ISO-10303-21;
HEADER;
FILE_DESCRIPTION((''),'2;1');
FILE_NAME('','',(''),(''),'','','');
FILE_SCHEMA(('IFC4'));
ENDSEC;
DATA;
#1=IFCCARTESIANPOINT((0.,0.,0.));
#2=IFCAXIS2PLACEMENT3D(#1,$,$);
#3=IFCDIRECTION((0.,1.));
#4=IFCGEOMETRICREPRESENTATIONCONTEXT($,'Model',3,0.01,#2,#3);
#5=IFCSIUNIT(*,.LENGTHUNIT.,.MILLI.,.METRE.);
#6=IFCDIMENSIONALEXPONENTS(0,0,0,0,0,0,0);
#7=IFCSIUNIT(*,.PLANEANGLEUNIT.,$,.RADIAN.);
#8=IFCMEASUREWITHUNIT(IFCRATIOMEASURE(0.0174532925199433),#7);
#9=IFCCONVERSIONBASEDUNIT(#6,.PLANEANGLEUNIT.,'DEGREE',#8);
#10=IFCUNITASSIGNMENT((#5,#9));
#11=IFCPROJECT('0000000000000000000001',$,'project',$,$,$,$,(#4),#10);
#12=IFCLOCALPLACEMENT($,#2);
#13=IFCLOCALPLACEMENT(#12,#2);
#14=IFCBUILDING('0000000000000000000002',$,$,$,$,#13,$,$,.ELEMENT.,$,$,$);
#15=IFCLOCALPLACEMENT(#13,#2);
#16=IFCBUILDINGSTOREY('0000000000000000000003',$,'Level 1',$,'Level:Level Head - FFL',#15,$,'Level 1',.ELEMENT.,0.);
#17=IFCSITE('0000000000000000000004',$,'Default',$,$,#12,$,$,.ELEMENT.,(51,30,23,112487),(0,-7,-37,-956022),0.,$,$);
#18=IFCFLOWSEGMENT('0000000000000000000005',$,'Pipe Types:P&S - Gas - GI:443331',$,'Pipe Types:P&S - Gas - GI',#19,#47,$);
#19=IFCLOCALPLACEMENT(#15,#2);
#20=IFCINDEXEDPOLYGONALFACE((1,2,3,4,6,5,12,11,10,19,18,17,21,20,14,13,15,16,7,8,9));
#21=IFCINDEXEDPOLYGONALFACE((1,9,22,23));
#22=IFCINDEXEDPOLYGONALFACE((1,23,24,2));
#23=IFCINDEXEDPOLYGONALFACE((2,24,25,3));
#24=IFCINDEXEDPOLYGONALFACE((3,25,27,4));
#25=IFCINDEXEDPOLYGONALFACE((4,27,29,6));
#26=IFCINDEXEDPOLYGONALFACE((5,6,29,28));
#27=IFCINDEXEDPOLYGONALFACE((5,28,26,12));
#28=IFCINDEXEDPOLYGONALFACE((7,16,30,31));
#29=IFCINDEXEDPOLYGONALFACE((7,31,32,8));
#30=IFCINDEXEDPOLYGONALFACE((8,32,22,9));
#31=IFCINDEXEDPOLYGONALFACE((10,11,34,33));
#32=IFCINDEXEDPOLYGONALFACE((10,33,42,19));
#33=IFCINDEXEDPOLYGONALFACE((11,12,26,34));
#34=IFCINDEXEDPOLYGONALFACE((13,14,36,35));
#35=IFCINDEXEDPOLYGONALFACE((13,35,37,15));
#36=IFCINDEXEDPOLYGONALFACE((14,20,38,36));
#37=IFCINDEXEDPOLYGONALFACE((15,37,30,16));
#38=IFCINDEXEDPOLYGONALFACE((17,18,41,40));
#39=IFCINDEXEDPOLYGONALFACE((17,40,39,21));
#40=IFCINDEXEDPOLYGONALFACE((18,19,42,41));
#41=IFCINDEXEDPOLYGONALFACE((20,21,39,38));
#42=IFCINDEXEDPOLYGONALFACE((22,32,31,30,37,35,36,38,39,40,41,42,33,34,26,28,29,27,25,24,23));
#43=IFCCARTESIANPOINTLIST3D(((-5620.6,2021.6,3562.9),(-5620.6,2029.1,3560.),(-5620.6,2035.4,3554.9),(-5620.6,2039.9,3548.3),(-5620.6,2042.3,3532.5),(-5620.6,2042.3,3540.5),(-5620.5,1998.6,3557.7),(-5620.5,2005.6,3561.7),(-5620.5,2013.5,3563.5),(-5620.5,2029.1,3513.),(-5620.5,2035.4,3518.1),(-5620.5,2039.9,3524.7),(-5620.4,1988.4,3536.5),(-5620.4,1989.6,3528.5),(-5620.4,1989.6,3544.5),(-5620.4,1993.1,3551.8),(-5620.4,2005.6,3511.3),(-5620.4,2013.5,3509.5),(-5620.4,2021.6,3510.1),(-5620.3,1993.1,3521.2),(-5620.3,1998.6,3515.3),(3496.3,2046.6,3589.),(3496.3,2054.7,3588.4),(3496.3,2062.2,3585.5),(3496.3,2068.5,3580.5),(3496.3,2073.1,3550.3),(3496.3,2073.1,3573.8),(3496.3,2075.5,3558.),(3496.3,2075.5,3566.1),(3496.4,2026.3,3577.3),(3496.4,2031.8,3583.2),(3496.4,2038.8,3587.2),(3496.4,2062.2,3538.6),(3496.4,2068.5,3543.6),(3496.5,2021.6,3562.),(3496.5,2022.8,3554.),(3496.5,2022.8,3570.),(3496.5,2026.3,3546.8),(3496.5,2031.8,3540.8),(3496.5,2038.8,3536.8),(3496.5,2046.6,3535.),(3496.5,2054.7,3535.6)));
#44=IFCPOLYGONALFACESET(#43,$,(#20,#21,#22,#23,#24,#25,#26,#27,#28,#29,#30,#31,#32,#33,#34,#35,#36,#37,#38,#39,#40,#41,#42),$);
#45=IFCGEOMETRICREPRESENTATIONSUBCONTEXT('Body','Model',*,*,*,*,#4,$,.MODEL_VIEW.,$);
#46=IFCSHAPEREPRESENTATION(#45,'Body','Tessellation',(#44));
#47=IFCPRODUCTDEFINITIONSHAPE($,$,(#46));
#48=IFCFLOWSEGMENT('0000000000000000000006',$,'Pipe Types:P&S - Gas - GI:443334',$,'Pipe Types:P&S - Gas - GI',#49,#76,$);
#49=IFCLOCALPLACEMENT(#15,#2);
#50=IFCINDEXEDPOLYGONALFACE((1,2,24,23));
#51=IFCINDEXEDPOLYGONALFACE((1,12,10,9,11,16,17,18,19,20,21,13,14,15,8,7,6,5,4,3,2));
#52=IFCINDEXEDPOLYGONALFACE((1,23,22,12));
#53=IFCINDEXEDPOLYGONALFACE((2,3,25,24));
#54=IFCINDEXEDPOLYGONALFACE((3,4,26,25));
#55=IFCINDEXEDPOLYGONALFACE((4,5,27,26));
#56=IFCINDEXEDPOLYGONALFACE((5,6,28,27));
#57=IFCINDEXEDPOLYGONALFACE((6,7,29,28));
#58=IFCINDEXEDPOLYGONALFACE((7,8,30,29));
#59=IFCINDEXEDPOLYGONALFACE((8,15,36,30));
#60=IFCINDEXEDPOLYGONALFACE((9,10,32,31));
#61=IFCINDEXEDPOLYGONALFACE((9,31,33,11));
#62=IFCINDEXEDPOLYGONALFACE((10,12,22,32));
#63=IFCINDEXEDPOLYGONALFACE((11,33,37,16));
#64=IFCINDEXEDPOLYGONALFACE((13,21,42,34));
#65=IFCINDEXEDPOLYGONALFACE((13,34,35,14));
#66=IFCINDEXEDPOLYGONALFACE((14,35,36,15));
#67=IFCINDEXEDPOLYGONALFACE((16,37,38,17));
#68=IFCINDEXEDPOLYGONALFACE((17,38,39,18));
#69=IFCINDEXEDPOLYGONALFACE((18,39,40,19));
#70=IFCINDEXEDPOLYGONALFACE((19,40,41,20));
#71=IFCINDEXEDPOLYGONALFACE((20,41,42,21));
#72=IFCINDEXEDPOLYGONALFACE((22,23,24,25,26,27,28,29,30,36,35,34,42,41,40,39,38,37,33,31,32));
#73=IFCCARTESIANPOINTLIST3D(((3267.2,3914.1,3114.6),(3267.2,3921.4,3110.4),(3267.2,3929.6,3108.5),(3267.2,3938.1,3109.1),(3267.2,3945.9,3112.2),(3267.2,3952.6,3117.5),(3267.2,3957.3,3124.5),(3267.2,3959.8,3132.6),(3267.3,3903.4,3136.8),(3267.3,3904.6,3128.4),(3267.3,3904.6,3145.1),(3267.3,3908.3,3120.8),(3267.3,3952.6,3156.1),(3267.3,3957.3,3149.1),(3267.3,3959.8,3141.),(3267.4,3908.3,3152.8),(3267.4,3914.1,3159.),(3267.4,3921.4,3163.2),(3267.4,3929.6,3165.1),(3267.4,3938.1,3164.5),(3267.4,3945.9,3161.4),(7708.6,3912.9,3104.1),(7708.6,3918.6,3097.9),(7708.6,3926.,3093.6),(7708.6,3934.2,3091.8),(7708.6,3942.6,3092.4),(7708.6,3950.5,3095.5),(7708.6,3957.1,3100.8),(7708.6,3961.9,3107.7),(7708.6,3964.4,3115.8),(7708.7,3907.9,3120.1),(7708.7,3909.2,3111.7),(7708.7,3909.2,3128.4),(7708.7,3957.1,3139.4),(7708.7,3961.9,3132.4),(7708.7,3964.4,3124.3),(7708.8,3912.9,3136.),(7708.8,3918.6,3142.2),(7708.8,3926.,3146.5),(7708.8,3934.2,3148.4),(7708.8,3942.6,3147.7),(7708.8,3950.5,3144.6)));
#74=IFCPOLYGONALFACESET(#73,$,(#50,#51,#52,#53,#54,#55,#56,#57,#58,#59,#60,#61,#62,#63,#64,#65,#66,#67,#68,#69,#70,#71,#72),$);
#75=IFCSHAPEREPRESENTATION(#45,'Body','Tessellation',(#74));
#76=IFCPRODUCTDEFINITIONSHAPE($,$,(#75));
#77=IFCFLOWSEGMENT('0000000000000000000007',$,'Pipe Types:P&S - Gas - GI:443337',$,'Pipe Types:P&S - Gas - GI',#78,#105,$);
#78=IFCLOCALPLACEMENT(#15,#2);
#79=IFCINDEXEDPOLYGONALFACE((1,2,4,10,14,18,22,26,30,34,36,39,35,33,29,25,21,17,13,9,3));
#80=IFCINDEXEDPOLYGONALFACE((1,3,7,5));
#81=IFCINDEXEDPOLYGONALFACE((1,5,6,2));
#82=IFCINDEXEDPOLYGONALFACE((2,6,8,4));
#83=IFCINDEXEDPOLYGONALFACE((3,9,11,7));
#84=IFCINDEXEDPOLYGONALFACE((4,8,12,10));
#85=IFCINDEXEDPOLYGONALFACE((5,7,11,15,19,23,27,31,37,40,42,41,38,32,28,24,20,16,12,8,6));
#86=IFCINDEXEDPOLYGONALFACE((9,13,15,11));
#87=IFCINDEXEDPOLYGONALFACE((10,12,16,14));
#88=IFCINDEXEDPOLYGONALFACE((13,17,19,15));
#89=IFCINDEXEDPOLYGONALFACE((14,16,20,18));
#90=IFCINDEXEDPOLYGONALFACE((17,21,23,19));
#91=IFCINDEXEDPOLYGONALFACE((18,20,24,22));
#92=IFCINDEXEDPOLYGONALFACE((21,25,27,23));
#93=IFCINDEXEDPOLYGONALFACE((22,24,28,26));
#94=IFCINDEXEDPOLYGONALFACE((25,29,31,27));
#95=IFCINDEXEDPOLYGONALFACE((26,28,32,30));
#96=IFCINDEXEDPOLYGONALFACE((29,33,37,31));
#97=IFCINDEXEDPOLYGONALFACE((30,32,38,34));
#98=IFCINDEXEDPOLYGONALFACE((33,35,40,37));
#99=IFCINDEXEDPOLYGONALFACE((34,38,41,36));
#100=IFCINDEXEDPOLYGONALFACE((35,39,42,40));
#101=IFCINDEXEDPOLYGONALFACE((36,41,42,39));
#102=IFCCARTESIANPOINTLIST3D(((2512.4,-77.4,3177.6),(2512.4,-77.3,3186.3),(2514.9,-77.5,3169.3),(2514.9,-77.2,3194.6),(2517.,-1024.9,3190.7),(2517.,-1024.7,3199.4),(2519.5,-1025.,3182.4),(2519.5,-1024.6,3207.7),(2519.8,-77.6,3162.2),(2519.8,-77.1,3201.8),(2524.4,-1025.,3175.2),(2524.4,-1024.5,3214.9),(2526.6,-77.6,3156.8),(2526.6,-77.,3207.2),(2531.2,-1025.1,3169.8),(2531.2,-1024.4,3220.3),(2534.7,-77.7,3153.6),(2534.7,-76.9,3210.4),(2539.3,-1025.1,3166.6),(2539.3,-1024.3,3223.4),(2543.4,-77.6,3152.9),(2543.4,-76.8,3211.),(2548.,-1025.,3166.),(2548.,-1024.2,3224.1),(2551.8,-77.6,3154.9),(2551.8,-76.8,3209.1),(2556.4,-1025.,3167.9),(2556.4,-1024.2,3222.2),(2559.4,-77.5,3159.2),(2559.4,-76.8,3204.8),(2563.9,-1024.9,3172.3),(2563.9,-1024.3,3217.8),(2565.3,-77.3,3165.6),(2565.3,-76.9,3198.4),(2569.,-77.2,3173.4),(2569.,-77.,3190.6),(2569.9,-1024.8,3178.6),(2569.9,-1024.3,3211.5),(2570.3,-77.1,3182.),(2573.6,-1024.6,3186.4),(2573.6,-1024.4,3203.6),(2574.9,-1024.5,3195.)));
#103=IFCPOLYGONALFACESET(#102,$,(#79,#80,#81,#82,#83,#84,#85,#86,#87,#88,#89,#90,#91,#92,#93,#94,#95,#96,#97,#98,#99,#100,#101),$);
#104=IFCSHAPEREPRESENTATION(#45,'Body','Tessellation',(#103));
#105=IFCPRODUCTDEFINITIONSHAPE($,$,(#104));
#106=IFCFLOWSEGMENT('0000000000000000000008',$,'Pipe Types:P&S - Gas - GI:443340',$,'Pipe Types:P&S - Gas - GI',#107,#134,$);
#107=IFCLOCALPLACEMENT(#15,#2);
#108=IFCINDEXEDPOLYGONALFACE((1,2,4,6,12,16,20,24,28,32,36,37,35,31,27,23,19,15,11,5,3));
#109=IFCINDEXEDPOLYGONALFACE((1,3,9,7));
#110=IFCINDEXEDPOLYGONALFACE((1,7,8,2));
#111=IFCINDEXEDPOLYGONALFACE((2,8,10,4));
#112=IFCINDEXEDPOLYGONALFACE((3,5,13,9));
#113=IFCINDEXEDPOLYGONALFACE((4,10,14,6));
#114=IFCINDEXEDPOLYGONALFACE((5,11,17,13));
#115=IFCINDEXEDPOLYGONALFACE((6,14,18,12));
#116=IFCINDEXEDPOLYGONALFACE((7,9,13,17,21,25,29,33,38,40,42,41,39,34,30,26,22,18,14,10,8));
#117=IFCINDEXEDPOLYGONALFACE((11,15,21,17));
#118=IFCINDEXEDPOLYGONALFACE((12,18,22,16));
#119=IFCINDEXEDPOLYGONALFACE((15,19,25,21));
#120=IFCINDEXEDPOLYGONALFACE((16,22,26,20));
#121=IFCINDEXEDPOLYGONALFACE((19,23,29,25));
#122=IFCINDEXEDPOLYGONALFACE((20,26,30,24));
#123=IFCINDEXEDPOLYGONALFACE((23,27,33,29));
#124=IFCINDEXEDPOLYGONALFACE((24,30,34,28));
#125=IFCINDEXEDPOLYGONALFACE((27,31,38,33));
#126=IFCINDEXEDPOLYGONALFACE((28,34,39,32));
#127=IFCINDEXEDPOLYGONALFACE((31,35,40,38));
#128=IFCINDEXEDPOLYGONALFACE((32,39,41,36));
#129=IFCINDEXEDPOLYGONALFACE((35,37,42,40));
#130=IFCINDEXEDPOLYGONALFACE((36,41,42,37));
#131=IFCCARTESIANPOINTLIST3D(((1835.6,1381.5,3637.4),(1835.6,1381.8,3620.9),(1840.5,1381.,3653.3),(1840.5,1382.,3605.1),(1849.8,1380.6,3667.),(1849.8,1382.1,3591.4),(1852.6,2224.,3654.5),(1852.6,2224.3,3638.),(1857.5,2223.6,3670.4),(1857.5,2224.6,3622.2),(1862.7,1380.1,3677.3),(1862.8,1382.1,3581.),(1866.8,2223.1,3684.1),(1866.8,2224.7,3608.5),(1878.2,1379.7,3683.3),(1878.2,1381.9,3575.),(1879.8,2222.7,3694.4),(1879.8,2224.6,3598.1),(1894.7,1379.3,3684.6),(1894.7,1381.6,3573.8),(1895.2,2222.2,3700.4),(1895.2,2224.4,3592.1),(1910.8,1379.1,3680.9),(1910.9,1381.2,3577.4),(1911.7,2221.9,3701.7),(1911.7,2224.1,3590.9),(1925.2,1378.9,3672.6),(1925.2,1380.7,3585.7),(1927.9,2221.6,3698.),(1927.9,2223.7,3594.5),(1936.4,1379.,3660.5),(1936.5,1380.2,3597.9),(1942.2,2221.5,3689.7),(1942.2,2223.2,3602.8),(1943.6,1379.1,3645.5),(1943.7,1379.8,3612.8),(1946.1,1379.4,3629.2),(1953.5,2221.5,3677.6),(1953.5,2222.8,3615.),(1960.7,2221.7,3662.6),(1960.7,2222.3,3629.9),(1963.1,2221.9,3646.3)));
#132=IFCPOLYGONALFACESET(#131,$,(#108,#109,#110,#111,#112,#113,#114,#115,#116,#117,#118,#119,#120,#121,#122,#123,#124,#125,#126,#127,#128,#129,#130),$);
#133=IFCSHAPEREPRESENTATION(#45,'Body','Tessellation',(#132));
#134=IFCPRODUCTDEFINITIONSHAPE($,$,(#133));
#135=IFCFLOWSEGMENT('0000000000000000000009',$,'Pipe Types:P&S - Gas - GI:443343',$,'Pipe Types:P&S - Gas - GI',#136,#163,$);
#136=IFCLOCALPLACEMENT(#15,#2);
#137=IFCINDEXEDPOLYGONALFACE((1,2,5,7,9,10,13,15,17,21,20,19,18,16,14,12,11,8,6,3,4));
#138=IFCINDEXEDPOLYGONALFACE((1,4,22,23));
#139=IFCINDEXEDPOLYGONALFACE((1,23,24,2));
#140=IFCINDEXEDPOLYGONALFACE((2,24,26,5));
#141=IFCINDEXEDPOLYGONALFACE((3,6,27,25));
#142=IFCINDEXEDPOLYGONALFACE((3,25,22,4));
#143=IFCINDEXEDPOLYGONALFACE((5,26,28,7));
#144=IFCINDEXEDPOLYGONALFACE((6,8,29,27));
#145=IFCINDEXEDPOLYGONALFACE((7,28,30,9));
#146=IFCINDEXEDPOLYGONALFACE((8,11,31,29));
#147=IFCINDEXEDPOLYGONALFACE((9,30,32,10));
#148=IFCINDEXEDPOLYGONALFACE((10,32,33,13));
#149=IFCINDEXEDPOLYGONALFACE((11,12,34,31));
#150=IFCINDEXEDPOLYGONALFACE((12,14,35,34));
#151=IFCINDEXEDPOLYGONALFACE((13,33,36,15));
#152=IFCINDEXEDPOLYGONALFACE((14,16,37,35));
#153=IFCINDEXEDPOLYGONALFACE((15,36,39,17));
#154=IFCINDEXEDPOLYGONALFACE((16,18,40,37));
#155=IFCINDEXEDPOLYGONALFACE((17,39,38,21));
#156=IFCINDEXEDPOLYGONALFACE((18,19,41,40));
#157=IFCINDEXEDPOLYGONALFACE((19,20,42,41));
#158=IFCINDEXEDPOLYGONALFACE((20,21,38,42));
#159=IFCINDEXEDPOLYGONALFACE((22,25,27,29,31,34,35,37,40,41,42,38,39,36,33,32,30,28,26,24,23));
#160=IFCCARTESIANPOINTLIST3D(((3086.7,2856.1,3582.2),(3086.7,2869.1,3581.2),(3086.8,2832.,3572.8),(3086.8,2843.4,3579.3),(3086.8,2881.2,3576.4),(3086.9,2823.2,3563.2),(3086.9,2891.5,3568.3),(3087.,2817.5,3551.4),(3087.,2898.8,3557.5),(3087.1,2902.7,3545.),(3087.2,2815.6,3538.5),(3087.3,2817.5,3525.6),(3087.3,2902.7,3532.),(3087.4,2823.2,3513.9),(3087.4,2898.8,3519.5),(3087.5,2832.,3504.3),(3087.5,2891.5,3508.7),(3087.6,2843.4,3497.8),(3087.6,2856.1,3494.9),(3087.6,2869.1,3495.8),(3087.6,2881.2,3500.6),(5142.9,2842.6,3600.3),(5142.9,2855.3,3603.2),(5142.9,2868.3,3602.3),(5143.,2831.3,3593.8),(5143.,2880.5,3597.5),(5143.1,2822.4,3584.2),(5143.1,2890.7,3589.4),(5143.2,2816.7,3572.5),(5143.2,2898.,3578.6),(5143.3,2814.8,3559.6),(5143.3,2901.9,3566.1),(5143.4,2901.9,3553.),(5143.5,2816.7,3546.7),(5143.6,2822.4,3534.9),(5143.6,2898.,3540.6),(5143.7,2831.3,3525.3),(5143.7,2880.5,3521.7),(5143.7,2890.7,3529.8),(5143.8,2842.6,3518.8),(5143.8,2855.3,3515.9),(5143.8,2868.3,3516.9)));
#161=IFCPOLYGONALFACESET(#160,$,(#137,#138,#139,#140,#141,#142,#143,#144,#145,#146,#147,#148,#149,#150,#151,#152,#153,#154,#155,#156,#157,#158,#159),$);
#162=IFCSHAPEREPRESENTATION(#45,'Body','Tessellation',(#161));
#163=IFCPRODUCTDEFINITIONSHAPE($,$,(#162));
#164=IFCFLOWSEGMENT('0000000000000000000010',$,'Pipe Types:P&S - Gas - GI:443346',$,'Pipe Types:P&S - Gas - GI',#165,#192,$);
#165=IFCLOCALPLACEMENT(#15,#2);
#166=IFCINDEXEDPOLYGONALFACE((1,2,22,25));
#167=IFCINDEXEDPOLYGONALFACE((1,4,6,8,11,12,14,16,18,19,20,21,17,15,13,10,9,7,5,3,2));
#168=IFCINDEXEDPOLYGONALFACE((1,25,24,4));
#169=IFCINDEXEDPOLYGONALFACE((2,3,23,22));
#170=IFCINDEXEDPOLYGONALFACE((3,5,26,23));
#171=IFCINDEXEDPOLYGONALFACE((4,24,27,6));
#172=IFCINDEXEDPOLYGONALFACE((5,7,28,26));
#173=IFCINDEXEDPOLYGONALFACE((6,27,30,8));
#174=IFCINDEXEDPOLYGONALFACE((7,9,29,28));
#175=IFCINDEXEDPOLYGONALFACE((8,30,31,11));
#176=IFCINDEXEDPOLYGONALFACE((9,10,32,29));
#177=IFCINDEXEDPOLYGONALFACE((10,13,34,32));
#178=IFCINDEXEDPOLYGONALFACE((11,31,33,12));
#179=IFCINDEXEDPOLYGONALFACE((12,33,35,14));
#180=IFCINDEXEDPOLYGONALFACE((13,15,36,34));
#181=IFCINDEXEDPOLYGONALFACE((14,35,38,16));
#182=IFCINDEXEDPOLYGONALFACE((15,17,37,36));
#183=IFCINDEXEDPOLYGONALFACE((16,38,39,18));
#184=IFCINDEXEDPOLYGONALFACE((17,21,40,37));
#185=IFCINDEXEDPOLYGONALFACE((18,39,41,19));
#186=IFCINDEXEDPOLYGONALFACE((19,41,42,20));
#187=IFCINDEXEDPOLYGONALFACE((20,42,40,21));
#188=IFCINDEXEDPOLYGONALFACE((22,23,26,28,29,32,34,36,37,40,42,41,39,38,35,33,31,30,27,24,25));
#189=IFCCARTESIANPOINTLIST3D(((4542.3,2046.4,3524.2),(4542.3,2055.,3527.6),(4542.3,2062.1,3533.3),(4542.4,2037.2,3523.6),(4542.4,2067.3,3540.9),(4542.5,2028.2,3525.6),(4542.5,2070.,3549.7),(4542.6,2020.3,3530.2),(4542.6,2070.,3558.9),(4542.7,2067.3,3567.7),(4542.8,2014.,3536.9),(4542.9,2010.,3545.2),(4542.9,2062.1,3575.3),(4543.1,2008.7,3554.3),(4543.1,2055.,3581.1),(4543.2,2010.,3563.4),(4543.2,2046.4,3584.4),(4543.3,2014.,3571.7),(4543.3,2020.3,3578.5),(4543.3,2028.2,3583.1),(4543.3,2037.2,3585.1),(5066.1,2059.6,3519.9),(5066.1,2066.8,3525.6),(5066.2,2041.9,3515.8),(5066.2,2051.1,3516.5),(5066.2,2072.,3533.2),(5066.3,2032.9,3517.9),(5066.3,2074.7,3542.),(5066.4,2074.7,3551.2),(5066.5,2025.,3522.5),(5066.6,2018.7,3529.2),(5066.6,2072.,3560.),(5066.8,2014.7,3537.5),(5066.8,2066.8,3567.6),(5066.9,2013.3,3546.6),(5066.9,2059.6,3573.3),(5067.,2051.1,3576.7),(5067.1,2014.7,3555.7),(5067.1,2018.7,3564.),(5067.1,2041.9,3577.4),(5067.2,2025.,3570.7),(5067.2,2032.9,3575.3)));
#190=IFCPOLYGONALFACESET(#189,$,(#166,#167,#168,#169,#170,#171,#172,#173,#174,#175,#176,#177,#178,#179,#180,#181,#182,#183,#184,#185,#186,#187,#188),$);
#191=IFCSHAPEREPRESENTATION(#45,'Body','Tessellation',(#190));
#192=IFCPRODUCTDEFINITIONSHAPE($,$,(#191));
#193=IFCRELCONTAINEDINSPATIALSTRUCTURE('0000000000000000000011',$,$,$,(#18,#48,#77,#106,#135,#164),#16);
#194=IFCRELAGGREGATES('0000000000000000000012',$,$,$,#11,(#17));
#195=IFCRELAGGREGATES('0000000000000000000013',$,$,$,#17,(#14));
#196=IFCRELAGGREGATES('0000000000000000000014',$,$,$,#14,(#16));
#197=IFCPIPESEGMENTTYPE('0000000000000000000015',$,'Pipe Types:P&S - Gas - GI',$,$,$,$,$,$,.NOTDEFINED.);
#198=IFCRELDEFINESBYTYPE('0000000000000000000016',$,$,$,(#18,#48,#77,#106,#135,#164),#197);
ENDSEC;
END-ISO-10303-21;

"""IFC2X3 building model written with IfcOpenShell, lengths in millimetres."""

from ifc_helpers import new_model, entity, si_unit, converted_unit, direction, frame, frame_2d, origin, origin_2d_with_axis, place, context, subcontext, project, spatial, circle, extrude, type_object, element, save


model = new_model("IFC2X3")

# Units and contexts
model_context = context("Model", 3, precision=0.01, world=origin(), true_north=direction((0.0, 1.0)))
body_context = subcontext(model_context, "Body", "Model", "MODEL_VIEW")
ifc_project = project(units=[si_unit("LENGTHUNIT", "METRE", prefix="MILLI"), converted_unit("PLANEANGLEUNIT", "DEGREE", entity("IfcRatioMeasure", 0.0174532925199433), si_unit("PLANEANGLEUNIT", "RADIAN"), dimensions=[0, 0, 0, 0, 0, 0, 0])], contexts=[model_context])

# Site, building, storey
site_placement = place(None, origin())
site = spatial("IfcSite", under=ifc_project, at=site_placement, Name="Default", CompositionType="ELEMENT", RefLatitude=(51, 30, 23, 112487), RefLongitude=(0, -7, -37, -956022), RefElevation=0.0)
building_placement = place(site_placement, origin())
building = spatial("IfcBuilding", under=site, at=building_placement, CompositionType="ELEMENT")
storey_placement = place(building_placement, origin())
storey = spatial("IfcBuildingStorey", under=building, at=storey_placement, Name="Level 1", ObjectType="Level:Level Head - FFL", LongName="Level 1", CompositionType="ELEMENT", Elevation=0.0)

# Flow segments
pipe_segment_type = type_object("IfcPipeSegmentType", Name="Pipe Types:P&S - Gas - GI", PredefinedType="NOTDEFINED")
flow_segment_1_placement = place(storey_placement, origin())
element("IfcFlowSegment", 1, at=flow_segment_1_placement, inside=storey, type_object=pipe_segment_type, Name="Pipe Types:P&S - Gas - GI:443331", ObjectType="Pipe Types:P&S - Gas - GI", context=body_context, shape_type="SweptSolid", body=[
    extrude(circle(Radius=27.1, at=origin_2d_with_axis()), frame((-5620.5, 2015.5, 3536.5), z_axis=(0.999989, 0.003634, 0.002799), x_axis=(0.003634, -0.999993, 0.0)), (0.0, 0.0, 1.0), 9117.0),
])
flow_segment_2_placement = place(storey_placement, origin())
element("IfcFlowSegment", 2, at=flow_segment_2_placement, inside=storey, type_object=pipe_segment_type, Name="Pipe Types:P&S - Gas - GI:443334", ObjectType="Pipe Types:P&S - Gas - GI", context=body_context, shape_type="SweptSolid", body=[
    extrude(circle(Radius=28.4, at=frame_2d((0.0, 0.0), x_axis=(1.0, 0.0))), frame((3267.3, 3931.8, 3136.8), z_axis=(0.999992, 0.00103, -0.003766), x_axis=(0.00103, -0.999999, 0.0)), (0.0, 0.0, 1.0), 4441.4),
])
flow_segment_3_placement = place(storey_placement, origin())
element("IfcFlowSegment", 3, at=flow_segment_3_placement, inside=storey, type_object=pipe_segment_type, Name="Pipe Types:P&S - Gas - GI:443337", ObjectType="Pipe Types:P&S - Gas - GI", context=body_context, shape_type="SweptSolid", body=[
    extrude(circle(Radius=29.1, at=frame_2d((0.0, 0.0), x_axis=(1.0, 0.0))), frame((2541.2, -77.2, 3182.0), z_axis=(0.004833, -0.999894, 0.01377), x_axis=(0.999988, 0.004833, 0.0)), (0.0, 0.0, 1.0), 947.5),
])
flow_segment_4_placement = place(storey_placement, origin())
element("IfcFlowSegment", 4, at=flow_segment_4_placement, inside=storey, type_object=pipe_segment_type, Name="Pipe Types:P&S - Gas - GI:443340", ObjectType="Pipe Types:P&S - Gas - GI", context=body_context, shape_type="SweptSolid", body=[
    extrude(circle(Radius=55.6, at=frame_2d((0.0, 0.0), x_axis=(1.0, 0.0))), frame((1890.5, 1380.5, 3629.2), z_axis=(0.0202, 0.99959, 0.020288), x_axis=(0.999796, -0.020204, 0.0)), (0.0, 0.0, 1.0), 842.9),
])
flow_segment_5_placement = place(storey_placement, origin())
element("IfcFlowSegment", 5, at=flow_segment_5_placement, inside=storey, type_object=pipe_segment_type, Name="Pipe Types:P&S - Gas - GI:443343", ObjectType="Pipe Types:P&S - Gas - GI", context=body_context, shape_type="SweptSolid", body=[
    extrude(circle(Radius=43.8, at=frame_2d((0.0, 0.0), x_axis=(1.0, 0.0))), frame((3087.2, 2859.4, 3538.5), z_axis=(0.999948, -0.000371, 0.010238), x_axis=(-0.000371, -1.0, 0.0)), (0.0, 0.0, 1.0), 2056.3),
])
flow_segment_6_placement = place(storey_placement, origin())
element("IfcFlowSegment", 6, at=flow_segment_6_placement, inside=storey, type_object=pipe_segment_type, Name="Pipe Types:P&S - Gas - GI:443346", ObjectType="Pipe Types:P&S - Gas - GI", context=body_context, shape_type="SweptSolid", body=[
    extrude(circle(Radius=30.9, at=frame_2d((0.0, 0.0), x_axis=(1.0, 0.0))), frame((4542.8, 2039.5, 3554.3), z_axis=(0.999852, 0.008951, -0.014711), x_axis=(0.008952, -0.99996, 0.0)), (0.0, 0.0, 1.0), 523.9),
])

save(model, "model.ifc")
